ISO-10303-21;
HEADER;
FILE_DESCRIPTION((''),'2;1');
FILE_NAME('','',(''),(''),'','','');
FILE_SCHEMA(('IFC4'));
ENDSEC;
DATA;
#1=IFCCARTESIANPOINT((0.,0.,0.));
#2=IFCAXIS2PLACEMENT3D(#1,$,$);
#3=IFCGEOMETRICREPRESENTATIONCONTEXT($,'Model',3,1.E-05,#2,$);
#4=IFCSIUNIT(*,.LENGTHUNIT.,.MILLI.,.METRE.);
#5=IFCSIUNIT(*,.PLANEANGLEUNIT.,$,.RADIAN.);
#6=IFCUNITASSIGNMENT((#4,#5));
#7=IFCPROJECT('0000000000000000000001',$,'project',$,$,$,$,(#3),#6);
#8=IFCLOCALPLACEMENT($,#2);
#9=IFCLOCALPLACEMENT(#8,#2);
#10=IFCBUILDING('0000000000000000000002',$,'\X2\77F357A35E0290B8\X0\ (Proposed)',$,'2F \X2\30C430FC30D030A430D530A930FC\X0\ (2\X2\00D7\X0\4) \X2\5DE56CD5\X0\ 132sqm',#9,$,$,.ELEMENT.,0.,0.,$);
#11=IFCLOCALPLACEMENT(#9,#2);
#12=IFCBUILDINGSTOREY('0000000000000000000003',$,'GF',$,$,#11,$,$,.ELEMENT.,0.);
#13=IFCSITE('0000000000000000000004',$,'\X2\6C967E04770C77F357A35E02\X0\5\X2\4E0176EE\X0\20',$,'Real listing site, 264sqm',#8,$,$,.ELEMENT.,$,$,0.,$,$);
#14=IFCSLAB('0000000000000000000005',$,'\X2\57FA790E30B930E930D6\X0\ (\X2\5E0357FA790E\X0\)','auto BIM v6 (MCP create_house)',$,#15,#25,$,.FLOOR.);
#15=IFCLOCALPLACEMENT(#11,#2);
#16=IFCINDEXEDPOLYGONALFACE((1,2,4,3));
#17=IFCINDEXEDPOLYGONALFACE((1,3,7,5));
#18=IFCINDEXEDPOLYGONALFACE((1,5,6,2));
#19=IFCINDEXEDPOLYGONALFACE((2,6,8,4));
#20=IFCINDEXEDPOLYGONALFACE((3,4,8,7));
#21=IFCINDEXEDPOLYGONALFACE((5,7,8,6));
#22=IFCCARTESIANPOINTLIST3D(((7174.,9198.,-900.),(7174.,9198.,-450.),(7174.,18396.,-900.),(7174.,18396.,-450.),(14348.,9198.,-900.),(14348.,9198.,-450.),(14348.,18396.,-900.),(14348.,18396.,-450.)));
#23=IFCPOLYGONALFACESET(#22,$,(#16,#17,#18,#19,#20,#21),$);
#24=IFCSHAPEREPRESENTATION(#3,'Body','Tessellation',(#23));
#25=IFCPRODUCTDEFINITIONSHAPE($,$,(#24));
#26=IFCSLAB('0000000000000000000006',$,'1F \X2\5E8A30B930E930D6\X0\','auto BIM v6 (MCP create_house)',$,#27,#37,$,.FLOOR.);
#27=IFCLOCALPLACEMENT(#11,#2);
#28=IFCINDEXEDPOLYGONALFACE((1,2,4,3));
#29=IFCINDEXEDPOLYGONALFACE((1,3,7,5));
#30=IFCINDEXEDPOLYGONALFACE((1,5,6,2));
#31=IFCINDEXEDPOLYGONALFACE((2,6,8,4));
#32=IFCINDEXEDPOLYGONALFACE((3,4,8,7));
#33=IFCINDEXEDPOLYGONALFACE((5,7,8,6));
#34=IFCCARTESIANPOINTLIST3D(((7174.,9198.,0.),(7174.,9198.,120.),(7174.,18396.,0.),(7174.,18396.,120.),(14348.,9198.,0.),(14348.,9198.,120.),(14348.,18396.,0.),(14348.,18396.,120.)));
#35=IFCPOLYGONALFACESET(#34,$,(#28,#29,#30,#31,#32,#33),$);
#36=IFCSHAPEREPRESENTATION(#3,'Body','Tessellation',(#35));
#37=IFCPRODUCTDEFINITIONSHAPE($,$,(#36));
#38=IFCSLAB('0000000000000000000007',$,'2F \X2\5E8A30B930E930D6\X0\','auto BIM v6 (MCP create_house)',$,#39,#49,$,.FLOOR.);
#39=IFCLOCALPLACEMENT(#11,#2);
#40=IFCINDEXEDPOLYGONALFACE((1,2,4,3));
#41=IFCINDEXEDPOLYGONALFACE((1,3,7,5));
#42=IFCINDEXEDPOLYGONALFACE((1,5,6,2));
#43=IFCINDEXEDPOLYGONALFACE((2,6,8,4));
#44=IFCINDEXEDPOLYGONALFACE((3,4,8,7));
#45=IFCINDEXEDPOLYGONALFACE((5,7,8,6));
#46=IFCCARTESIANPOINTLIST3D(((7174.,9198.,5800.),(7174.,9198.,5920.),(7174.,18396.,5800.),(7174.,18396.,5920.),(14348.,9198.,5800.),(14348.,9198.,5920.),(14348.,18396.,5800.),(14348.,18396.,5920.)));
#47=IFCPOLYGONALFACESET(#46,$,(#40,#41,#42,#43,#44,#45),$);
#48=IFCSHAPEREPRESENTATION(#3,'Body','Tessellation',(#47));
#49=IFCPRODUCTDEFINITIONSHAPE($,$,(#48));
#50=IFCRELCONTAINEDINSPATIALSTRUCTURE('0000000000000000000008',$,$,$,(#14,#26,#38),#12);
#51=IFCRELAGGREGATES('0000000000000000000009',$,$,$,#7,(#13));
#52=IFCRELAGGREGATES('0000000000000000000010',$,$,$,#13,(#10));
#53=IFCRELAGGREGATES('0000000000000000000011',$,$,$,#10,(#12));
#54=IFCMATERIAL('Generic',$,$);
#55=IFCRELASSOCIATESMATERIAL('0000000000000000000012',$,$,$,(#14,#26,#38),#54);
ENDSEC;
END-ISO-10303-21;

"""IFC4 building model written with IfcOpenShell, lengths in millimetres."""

from ifc_helpers import new_model, si_unit, frame, frame_2d, origin, place, context, project, spatial, rectangle, extrude, material, element, save


model = new_model("IFC4")

# Units and contexts
model_context = context("Model", 3, precision=1e-05, world=origin())
ifc_project = project(units=[si_unit("LENGTHUNIT", "METRE", prefix="MILLI"), si_unit("PLANEANGLEUNIT", "RADIAN")], contexts=[model_context])

# Site, building, storey
site_placement = place(None, origin())
site = spatial("IfcSite", under=ifc_project, at=site_placement, Name="沖縄県石垣市5丁目20", ObjectType="Real listing site, 264sqm", CompositionType="ELEMENT", RefElevation=0.0)
building_placement = place(site_placement, origin())
building = spatial("IfcBuilding", under=site, at=building_placement, Name="石垣市邸 (Proposed)", ObjectType="2F ツーバイフォー (2×4) 工法 132sqm", CompositionType="ELEMENT", ElevationOfRefHeight=0.0, ElevationOfTerrain=0.0)
storey_placement = place(building_placement, origin())
storey = spatial("IfcBuildingStorey", under=building, at=storey_placement, Name="GF", CompositionType="ELEMENT", Elevation=0.0)

# Slabs
ifc_material = material(Name="Generic")
slab_1_placement = place(storey_placement, frame((3587.0, 4599.0, -450.0)))
element("IfcSlab", 1, at=slab_1_placement, inside=storey, material=ifc_material, Name="基礎スラブ (布基礎)", Description="auto BIM v6 (MCP create_house)", PredefinedType="FLOOR", context=model_context, shape_type="SweptSolid", body=[
    extrude(rectangle(XDim=7174.0, YDim=9198.0, at=frame_2d((3587.0, 4599.0))), frame((3587.0, 4599.0, -450.0)), (0.0, 0.0, 1.0), 450.0),
])
slab_2_placement = place(storey_placement, frame((3587.0, 4599.0, 0.0)))
element("IfcSlab", 2, at=slab_2_placement, inside=storey, material=ifc_material, Name="1F 床スラブ", Description="auto BIM v6 (MCP create_house)", PredefinedType="FLOOR", context=model_context, shape_type="SweptSolid", body=[
    extrude(rectangle(XDim=7174.0, YDim=9198.0, at=frame_2d((3587.0, 4599.0))), frame((3587.0, 4599.0, 0.0)), (0.0, 0.0, 1.0), 120.0),
])
slab_3_placement = place(storey_placement, frame((3587.0, 4599.0, 2900.0)))
element("IfcSlab", 3, at=slab_3_placement, inside=storey, material=ifc_material, Name="2F 床スラブ", Description="auto BIM v6 (MCP create_house)", PredefinedType="FLOOR", context=model_context, shape_type="SweptSolid", body=[
    extrude(rectangle(XDim=7174.0, YDim=9198.0, at=frame_2d((3587.0, 4599.0))), frame((3587.0, 4599.0, 2900.0)), (0.0, 0.0, 1.0), 120.0),
])

save(model, "model.ifc")
